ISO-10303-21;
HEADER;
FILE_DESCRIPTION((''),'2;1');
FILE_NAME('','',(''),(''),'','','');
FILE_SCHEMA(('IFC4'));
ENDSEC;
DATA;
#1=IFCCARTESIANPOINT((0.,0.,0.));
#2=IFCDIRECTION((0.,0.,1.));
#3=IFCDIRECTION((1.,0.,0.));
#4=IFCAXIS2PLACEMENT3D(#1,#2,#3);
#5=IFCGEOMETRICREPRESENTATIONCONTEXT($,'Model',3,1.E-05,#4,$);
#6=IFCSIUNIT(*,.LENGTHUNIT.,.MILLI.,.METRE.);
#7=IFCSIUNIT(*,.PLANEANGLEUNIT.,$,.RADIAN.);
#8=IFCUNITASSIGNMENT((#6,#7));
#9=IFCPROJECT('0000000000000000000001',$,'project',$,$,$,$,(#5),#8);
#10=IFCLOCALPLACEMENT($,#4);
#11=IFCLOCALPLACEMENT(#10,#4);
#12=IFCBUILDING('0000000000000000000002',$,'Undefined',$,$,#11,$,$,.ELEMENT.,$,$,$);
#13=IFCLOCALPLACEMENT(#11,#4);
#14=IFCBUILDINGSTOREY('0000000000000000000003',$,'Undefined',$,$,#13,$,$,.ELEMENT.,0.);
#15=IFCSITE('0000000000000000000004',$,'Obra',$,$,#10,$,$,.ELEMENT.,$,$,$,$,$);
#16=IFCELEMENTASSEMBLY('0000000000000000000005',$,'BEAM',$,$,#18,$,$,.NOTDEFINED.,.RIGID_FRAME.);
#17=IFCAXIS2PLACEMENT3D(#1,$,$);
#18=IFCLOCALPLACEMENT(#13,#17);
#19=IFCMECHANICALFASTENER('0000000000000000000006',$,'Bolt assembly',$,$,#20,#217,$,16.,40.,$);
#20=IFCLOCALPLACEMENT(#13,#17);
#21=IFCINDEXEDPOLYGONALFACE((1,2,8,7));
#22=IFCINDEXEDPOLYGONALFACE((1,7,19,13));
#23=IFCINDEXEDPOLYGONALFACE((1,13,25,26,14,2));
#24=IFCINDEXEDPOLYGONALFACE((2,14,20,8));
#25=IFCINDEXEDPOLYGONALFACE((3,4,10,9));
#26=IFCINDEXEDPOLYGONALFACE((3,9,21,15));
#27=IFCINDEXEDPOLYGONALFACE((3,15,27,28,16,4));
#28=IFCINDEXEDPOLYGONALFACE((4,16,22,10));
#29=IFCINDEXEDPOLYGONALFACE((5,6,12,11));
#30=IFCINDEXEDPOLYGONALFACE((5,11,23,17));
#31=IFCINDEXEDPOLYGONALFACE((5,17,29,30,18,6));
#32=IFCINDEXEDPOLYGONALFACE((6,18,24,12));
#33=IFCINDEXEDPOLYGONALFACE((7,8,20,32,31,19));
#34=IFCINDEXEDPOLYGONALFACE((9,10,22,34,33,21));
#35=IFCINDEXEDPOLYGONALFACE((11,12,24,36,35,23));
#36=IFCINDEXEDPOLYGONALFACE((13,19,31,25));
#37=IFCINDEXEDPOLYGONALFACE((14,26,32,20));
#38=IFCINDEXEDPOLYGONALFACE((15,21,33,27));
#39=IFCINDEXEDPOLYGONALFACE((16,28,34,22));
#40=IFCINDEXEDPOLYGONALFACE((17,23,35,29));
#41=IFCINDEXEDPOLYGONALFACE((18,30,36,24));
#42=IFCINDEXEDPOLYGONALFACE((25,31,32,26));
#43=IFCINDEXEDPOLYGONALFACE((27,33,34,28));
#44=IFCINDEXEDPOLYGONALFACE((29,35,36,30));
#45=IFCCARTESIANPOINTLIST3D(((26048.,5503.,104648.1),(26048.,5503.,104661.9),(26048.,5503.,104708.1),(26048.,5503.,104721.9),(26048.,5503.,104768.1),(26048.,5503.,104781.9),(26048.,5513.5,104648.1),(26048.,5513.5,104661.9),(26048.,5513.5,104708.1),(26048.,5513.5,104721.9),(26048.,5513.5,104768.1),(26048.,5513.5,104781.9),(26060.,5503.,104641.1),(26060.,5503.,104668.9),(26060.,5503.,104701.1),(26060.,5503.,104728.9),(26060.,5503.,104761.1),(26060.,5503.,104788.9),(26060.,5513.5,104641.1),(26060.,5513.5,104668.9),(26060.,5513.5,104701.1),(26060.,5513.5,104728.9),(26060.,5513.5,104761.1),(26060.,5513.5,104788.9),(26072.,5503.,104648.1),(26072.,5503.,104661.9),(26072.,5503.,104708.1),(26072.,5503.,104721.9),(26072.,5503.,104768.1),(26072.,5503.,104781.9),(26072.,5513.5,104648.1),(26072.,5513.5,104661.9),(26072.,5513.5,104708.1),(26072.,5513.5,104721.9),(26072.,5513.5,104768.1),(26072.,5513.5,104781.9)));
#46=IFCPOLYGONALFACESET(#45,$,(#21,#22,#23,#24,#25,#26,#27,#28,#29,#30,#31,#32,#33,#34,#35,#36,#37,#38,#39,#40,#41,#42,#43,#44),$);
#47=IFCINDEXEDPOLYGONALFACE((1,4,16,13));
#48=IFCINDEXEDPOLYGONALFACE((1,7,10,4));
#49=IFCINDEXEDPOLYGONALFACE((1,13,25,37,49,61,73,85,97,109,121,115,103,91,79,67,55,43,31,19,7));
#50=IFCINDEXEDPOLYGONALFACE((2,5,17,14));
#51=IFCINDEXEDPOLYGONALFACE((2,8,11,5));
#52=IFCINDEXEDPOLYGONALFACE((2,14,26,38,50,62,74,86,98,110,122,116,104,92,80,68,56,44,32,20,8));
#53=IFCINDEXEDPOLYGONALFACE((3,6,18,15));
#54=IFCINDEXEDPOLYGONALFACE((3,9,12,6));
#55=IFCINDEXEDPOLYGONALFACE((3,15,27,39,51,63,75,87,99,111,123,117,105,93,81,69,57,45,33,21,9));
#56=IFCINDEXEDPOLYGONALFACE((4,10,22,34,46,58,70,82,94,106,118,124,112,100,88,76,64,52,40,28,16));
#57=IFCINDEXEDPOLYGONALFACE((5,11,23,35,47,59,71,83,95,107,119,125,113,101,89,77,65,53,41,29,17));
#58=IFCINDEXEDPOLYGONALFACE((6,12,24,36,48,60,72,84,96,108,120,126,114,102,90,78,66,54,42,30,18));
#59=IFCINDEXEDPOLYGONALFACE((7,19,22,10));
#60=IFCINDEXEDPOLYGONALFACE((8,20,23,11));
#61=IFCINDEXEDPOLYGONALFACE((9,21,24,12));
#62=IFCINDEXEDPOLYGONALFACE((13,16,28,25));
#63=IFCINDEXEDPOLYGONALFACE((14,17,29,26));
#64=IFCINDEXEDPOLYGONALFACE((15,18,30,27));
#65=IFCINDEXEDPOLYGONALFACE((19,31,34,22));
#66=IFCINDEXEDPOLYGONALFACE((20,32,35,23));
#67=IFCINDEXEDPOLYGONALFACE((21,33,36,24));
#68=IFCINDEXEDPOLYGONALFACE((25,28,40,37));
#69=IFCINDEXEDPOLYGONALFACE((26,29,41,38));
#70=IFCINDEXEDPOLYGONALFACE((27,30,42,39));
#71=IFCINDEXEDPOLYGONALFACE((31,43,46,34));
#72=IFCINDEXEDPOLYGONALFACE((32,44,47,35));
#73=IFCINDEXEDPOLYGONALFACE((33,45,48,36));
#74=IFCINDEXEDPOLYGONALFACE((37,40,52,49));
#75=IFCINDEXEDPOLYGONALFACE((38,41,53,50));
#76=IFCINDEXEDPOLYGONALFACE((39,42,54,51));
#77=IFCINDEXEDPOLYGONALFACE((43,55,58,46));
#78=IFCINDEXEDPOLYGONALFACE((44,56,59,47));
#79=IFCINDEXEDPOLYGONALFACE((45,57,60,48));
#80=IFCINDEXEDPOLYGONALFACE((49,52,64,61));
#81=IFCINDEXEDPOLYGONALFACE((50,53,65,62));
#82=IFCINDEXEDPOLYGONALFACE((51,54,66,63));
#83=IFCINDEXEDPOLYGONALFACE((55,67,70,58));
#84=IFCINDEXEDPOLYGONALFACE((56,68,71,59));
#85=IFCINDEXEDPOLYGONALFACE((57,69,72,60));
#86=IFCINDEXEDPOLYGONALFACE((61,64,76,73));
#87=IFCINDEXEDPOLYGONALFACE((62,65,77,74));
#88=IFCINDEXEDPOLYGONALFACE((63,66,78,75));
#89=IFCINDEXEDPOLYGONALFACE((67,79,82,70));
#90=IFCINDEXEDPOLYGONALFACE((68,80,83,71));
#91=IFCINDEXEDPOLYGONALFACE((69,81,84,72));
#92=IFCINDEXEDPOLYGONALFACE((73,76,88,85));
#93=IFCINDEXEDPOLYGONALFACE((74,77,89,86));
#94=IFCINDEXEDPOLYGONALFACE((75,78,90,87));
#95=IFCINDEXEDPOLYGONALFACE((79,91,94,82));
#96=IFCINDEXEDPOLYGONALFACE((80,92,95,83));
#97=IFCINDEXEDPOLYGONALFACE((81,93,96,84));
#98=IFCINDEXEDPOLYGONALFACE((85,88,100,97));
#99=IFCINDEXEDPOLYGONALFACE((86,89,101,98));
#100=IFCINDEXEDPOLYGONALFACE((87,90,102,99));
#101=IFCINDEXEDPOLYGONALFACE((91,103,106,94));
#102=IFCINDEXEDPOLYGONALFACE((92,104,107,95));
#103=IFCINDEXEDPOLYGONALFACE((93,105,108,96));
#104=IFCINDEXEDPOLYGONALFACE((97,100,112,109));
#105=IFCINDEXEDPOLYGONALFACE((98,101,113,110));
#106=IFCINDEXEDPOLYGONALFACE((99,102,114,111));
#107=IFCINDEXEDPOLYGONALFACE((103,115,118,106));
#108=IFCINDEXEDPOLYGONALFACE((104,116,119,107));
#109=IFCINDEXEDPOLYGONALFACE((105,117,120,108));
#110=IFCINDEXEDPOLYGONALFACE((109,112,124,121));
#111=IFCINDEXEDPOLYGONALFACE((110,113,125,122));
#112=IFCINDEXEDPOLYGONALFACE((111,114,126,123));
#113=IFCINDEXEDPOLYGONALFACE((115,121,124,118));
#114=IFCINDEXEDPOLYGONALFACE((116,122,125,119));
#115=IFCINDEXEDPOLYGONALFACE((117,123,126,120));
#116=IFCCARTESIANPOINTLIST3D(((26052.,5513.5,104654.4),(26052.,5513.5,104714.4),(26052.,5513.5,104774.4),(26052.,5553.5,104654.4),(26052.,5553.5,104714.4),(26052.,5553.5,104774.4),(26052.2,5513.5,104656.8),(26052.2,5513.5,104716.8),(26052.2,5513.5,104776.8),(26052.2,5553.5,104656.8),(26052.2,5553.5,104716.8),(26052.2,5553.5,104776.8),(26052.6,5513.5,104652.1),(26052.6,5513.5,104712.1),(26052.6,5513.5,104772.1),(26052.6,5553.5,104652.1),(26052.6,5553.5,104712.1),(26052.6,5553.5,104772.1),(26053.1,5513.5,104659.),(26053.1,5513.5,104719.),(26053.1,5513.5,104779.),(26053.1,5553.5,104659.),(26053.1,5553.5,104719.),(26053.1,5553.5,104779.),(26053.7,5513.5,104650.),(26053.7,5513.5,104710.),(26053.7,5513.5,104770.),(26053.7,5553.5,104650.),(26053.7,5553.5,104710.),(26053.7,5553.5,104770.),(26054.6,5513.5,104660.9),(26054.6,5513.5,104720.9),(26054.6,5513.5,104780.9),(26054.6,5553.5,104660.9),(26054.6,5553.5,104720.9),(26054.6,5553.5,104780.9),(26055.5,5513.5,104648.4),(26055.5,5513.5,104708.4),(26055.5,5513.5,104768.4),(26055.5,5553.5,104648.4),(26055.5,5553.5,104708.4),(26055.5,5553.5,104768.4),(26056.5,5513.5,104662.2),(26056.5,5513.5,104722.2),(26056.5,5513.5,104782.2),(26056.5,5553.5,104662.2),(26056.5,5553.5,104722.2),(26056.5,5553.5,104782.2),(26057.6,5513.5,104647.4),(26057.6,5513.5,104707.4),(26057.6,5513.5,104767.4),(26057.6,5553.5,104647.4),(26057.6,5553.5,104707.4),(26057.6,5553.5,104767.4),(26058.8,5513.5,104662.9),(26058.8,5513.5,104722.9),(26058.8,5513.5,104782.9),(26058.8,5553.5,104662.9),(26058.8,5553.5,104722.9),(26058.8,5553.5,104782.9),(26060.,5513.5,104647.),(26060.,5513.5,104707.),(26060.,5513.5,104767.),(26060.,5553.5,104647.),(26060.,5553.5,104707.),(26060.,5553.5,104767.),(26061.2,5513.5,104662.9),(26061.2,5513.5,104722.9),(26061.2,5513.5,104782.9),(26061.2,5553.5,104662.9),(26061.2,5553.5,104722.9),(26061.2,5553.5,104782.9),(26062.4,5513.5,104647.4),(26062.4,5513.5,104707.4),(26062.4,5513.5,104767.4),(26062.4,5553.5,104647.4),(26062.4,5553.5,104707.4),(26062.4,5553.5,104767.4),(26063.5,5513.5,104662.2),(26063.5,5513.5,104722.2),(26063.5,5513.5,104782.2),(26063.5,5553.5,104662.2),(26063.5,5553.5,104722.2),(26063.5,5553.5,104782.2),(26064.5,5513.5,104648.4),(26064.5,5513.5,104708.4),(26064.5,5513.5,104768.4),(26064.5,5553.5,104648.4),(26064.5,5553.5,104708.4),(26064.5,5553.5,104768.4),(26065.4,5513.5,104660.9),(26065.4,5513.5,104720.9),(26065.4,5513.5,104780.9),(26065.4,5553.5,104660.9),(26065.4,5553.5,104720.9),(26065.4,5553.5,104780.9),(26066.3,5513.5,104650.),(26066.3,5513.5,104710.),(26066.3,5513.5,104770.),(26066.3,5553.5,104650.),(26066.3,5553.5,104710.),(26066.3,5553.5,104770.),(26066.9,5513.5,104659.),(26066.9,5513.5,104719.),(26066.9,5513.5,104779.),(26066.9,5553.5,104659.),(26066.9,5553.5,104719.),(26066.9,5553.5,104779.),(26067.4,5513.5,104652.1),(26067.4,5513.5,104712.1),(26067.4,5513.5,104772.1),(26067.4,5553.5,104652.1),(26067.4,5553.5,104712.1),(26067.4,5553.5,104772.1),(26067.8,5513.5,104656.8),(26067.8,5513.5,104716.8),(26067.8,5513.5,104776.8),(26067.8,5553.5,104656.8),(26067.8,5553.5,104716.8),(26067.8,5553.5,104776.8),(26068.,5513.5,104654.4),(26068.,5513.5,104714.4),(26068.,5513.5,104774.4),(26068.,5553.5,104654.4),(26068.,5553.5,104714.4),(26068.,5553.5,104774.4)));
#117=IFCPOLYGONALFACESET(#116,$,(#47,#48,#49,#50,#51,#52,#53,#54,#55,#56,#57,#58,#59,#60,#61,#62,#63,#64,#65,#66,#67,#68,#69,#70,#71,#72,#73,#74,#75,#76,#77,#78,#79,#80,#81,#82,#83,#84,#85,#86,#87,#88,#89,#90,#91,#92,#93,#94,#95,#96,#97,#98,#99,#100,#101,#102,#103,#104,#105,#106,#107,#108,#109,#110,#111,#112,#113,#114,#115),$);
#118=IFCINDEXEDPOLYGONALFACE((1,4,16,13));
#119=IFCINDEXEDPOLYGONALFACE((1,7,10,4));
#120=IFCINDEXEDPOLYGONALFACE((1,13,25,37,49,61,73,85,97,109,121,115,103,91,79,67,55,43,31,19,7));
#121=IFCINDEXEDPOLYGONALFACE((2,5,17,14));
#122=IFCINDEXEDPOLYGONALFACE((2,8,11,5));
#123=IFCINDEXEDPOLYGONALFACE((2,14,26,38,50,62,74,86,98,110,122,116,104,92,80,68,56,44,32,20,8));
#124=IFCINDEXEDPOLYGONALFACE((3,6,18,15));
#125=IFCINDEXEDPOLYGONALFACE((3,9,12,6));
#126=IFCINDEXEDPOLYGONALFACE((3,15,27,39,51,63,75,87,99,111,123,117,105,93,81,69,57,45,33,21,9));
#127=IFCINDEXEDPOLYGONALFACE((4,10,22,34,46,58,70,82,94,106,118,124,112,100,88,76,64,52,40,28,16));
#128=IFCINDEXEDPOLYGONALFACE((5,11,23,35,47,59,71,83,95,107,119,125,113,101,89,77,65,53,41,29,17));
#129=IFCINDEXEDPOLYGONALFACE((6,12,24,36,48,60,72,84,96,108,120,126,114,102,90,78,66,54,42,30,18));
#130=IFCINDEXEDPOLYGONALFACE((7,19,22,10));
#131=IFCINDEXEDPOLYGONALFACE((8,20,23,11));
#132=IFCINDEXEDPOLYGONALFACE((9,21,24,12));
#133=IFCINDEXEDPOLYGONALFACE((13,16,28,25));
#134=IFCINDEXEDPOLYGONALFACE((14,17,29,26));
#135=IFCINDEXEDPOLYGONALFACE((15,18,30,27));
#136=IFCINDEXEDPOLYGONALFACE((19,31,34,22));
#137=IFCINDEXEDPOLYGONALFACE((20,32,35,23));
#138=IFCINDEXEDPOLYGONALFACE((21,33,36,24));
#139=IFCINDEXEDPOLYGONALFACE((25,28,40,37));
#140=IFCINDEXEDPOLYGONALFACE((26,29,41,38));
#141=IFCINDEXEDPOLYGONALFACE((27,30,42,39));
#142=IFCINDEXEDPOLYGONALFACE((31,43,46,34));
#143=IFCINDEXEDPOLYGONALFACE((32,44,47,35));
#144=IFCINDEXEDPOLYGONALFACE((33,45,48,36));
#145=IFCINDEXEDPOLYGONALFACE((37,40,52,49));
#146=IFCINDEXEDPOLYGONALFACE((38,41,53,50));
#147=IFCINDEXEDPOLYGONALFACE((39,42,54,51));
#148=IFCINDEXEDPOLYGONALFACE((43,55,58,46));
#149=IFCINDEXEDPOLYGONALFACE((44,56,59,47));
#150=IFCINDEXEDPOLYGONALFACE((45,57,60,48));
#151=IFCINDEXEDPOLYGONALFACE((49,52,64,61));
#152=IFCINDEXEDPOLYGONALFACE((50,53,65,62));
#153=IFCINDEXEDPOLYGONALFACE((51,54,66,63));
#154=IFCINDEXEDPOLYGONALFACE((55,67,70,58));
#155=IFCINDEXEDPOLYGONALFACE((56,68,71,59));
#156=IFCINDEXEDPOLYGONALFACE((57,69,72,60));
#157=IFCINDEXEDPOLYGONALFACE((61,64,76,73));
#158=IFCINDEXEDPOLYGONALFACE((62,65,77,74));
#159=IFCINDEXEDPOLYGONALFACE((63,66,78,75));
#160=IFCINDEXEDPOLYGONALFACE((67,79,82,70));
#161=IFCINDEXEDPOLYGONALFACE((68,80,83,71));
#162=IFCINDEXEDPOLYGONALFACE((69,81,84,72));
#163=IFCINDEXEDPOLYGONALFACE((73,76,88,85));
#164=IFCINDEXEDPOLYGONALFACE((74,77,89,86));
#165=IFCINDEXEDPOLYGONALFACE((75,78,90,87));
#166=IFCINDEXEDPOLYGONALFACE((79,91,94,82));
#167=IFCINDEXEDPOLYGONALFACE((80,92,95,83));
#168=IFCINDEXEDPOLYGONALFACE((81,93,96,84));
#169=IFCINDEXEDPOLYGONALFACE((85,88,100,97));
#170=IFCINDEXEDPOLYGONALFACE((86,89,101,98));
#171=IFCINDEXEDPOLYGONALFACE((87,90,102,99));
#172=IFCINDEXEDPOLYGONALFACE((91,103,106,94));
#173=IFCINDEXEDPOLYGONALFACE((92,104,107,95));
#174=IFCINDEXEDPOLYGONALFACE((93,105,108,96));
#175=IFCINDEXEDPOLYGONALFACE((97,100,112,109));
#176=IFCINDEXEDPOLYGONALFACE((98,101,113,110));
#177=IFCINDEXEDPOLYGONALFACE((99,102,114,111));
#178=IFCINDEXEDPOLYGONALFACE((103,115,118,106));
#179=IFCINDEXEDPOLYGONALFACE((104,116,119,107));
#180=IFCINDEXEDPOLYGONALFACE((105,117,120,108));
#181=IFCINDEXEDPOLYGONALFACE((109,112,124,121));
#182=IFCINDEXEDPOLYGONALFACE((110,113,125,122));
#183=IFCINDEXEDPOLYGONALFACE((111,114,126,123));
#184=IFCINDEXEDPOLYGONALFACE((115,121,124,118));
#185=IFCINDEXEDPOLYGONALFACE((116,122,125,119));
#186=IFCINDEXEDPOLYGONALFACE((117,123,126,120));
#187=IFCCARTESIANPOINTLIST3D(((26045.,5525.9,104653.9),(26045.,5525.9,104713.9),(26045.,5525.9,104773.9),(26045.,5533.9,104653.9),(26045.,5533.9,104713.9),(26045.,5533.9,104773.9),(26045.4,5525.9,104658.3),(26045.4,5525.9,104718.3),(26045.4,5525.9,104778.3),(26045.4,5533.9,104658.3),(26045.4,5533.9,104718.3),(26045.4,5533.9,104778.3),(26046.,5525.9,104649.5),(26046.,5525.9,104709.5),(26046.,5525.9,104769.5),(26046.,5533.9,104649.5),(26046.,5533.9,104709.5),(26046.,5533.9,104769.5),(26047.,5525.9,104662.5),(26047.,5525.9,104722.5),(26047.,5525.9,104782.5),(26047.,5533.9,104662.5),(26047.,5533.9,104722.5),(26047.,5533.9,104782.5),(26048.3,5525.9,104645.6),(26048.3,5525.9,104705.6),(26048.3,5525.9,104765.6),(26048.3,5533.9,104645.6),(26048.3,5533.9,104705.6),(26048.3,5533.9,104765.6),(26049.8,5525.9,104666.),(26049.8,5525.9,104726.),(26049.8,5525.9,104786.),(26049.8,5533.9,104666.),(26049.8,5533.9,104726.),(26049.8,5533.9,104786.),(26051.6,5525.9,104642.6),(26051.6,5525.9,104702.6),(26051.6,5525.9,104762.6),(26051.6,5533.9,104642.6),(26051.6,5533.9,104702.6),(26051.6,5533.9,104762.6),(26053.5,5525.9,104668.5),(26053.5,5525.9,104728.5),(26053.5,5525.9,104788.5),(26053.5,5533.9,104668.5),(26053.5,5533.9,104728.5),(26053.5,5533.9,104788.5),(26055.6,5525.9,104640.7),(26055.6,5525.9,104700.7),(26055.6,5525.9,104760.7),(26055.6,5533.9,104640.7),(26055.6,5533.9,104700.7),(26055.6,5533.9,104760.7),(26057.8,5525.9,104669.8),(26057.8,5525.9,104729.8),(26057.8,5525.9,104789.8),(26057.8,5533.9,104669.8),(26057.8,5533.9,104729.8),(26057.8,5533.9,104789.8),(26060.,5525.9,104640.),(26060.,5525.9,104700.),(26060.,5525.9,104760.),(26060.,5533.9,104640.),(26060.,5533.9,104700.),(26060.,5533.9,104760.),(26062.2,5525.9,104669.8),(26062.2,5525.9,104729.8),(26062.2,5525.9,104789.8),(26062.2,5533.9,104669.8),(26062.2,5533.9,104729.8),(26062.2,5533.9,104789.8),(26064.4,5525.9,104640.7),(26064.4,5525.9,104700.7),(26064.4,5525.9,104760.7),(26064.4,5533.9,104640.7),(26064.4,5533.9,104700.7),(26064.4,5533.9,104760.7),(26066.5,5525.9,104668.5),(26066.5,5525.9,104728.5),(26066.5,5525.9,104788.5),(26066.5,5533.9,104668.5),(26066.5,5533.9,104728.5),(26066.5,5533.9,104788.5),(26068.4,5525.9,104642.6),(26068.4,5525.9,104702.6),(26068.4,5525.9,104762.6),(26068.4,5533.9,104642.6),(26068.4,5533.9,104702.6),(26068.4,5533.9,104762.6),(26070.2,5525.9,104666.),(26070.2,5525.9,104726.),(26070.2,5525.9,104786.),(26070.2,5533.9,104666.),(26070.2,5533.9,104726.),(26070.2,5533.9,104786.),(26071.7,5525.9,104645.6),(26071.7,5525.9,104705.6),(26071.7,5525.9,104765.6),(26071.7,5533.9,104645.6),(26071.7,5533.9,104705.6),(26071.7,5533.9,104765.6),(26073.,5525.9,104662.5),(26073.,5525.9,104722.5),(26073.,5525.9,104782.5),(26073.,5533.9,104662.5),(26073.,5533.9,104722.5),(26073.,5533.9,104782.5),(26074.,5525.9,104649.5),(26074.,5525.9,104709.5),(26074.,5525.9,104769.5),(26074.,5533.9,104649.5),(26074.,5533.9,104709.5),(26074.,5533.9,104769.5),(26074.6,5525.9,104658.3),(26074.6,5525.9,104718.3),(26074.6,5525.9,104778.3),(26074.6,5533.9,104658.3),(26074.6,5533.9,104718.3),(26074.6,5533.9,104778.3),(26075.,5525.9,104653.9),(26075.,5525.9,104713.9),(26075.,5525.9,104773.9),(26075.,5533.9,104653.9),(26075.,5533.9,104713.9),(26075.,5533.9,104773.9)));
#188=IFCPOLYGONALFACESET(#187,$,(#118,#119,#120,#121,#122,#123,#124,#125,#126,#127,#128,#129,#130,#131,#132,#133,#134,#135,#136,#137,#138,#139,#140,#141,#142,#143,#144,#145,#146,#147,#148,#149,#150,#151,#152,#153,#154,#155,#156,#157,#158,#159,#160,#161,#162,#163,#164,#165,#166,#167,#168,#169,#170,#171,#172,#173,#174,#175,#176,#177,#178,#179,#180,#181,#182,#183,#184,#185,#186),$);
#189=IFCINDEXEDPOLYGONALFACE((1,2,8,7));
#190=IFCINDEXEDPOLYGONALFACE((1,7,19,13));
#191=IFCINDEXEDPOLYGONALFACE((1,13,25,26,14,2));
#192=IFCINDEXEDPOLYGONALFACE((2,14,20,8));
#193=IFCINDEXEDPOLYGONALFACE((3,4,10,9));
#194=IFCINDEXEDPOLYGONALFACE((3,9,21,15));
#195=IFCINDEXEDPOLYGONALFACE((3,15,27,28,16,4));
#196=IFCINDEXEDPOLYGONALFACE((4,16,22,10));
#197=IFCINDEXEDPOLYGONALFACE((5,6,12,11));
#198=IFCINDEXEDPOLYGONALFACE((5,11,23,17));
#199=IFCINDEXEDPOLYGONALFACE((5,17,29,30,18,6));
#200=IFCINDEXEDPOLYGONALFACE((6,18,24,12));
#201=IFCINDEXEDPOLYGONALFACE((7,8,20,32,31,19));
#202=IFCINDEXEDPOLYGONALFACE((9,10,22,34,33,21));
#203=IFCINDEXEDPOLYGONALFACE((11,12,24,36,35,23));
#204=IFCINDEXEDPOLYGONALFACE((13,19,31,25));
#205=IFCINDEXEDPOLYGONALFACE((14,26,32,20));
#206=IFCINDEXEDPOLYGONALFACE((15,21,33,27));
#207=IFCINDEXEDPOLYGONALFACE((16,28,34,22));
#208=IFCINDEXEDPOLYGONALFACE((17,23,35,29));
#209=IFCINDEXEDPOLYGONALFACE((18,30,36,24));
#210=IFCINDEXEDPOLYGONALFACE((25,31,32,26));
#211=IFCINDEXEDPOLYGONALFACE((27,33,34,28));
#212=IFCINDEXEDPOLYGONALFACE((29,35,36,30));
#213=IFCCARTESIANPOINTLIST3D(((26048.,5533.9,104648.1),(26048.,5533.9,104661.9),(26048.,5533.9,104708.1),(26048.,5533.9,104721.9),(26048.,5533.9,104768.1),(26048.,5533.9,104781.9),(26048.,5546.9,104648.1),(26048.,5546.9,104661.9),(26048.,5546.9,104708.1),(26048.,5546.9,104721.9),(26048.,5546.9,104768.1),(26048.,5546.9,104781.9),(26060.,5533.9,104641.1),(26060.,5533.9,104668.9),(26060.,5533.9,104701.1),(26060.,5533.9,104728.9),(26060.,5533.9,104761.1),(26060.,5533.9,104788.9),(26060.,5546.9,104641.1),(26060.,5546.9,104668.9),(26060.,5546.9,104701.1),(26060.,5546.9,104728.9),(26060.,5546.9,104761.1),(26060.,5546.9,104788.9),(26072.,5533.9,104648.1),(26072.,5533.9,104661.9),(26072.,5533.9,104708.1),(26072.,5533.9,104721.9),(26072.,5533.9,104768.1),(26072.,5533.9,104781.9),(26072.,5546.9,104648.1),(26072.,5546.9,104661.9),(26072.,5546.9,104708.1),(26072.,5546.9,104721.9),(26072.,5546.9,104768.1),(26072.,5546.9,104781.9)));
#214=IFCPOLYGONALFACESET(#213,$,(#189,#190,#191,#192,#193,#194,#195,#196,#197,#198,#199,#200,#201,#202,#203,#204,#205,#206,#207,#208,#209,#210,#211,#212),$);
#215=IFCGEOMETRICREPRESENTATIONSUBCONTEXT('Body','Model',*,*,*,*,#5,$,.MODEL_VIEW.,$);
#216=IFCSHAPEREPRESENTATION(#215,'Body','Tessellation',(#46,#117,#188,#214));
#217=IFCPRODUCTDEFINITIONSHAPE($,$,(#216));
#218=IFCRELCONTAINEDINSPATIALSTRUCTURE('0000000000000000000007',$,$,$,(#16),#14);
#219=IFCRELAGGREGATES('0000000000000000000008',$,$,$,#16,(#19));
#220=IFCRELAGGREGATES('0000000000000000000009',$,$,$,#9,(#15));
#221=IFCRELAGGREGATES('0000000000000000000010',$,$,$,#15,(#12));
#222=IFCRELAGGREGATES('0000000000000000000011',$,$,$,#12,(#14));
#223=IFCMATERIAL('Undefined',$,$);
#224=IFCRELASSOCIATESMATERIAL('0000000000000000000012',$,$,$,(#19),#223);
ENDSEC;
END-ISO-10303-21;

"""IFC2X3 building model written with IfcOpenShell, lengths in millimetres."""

from ifc_helpers import new_model, si_unit, frame, origin_with_axes, origin_2d_with_axis, place, context, subcontext, project, spatial, polyline, circle, outline, extrude, source, transform, mapped, material, element, aggregate, save


model = new_model("IFC2X3")

# Units and contexts
model_context = context("Model", 3, precision=1e-05, world=origin_with_axes())
body_context = subcontext(model_context, "Body", "Model", "MODEL_VIEW")
ifc_project = project(units=[si_unit("LENGTHUNIT", "METRE", prefix="MILLI"), si_unit("PLANEANGLEUNIT", "RADIAN")], contexts=[model_context])

# Site, building, storey
site_placement = place(None, origin_with_axes())
site = spatial("IfcSite", under=ifc_project, at=site_placement, Name="Obra", CompositionType="ELEMENT")
building_placement = place(site_placement, origin_with_axes())
building = spatial("IfcBuilding", under=site, at=building_placement, Name="Undefined", CompositionType="ELEMENT")
storey_placement = place(building_placement, origin_with_axes())
storey = spatial("IfcBuildingStorey", under=building, at=storey_placement, Name="Undefined", CompositionType="ELEMENT", Elevation=0.0)

# Element assembly
assembly_1_placement = place(storey_placement, origin_with_axes())
assembly_1 = element("IfcElementAssembly", 1, at=assembly_1_placement, inside=storey, Name="BEAM", AssemblyPlace="NOTDEFINED", PredefinedType="RIGID_FRAME")

# Shared definitions
ifc_material_1 = material(Name="Undefined")

# Mechanical fastener
shared_shape_1 = source(origin_with_axes(), body_context, "Body", "SweptSolid", [
    extrude(outline(polyline([(13.9, 0.0), (6.9, 12.0), (-6.9, 12.0), (-13.9, 0.0), (-6.9, -12.0), (6.9, -12.0), (13.9, 0.0)])), frame((0.0, -19.7, 0.0), z_axis=(0.0, 1.0, 0.0), x_axis=(1.0, 0.0, 0.0)), (0.0, 0.0, 1.0), 10.6),
    extrude(circle(Radius=8.0, at=origin_2d_with_axis()), frame((0.0, -9.1, 0.0), z_axis=(0.0, 1.0, 0.0), x_axis=(1.0, 0.0, 0.0)), (0.0, 0.0, 1.0), 40.0),
    extrude(circle(Radius=15.0, at=origin_2d_with_axis()), frame((0.0, 3.3, 0.0), z_axis=(0.0, 1.0, 0.0), x_axis=(1.0, 0.0, 0.0)), (0.0, 0.0, 1.0), 8.0),
    extrude(outline(polyline([(13.9, 0.0), (6.9, 12.0), (-6.9, 12.0), (-13.9, 0.0), (-6.9, -12.0), (6.9, -12.0), (13.9, 0.0)])), frame((0.0, 11.3, 0.0), z_axis=(0.0, 1.0, 0.0), x_axis=(1.0, 0.0, 0.0)), (0.0, 0.0, 1.0), 13.0),
])
mechanical_fastener_1_placement = place(assembly_1_placement, frame((26010.0, 5522.6, 104835.0), z_axis=(1.0, 0.0, 0.0), x_axis=(0.0, 0.0, -1.0)))
mechanical_fastener_1 = element("IfcMechanicalFastener", 2, at=mechanical_fastener_1_placement, material=ifc_material_1, Name="Bolt assembly", NominalDiameter=16.0, NominalLength=40.0, context=body_context, shape_type="MappedRepresentation", body=[
    mapped(shared_shape_1, transform((60.0, 0.0, 50.0))),
    mapped(shared_shape_1, transform((120.0, 0.0, 50.0))),
    mapped(shared_shape_1, transform((180.0, 0.0, 50.0))),
])
aggregate(assembly_1, [mechanical_fastener_1])

save(model, "model.ifc")
